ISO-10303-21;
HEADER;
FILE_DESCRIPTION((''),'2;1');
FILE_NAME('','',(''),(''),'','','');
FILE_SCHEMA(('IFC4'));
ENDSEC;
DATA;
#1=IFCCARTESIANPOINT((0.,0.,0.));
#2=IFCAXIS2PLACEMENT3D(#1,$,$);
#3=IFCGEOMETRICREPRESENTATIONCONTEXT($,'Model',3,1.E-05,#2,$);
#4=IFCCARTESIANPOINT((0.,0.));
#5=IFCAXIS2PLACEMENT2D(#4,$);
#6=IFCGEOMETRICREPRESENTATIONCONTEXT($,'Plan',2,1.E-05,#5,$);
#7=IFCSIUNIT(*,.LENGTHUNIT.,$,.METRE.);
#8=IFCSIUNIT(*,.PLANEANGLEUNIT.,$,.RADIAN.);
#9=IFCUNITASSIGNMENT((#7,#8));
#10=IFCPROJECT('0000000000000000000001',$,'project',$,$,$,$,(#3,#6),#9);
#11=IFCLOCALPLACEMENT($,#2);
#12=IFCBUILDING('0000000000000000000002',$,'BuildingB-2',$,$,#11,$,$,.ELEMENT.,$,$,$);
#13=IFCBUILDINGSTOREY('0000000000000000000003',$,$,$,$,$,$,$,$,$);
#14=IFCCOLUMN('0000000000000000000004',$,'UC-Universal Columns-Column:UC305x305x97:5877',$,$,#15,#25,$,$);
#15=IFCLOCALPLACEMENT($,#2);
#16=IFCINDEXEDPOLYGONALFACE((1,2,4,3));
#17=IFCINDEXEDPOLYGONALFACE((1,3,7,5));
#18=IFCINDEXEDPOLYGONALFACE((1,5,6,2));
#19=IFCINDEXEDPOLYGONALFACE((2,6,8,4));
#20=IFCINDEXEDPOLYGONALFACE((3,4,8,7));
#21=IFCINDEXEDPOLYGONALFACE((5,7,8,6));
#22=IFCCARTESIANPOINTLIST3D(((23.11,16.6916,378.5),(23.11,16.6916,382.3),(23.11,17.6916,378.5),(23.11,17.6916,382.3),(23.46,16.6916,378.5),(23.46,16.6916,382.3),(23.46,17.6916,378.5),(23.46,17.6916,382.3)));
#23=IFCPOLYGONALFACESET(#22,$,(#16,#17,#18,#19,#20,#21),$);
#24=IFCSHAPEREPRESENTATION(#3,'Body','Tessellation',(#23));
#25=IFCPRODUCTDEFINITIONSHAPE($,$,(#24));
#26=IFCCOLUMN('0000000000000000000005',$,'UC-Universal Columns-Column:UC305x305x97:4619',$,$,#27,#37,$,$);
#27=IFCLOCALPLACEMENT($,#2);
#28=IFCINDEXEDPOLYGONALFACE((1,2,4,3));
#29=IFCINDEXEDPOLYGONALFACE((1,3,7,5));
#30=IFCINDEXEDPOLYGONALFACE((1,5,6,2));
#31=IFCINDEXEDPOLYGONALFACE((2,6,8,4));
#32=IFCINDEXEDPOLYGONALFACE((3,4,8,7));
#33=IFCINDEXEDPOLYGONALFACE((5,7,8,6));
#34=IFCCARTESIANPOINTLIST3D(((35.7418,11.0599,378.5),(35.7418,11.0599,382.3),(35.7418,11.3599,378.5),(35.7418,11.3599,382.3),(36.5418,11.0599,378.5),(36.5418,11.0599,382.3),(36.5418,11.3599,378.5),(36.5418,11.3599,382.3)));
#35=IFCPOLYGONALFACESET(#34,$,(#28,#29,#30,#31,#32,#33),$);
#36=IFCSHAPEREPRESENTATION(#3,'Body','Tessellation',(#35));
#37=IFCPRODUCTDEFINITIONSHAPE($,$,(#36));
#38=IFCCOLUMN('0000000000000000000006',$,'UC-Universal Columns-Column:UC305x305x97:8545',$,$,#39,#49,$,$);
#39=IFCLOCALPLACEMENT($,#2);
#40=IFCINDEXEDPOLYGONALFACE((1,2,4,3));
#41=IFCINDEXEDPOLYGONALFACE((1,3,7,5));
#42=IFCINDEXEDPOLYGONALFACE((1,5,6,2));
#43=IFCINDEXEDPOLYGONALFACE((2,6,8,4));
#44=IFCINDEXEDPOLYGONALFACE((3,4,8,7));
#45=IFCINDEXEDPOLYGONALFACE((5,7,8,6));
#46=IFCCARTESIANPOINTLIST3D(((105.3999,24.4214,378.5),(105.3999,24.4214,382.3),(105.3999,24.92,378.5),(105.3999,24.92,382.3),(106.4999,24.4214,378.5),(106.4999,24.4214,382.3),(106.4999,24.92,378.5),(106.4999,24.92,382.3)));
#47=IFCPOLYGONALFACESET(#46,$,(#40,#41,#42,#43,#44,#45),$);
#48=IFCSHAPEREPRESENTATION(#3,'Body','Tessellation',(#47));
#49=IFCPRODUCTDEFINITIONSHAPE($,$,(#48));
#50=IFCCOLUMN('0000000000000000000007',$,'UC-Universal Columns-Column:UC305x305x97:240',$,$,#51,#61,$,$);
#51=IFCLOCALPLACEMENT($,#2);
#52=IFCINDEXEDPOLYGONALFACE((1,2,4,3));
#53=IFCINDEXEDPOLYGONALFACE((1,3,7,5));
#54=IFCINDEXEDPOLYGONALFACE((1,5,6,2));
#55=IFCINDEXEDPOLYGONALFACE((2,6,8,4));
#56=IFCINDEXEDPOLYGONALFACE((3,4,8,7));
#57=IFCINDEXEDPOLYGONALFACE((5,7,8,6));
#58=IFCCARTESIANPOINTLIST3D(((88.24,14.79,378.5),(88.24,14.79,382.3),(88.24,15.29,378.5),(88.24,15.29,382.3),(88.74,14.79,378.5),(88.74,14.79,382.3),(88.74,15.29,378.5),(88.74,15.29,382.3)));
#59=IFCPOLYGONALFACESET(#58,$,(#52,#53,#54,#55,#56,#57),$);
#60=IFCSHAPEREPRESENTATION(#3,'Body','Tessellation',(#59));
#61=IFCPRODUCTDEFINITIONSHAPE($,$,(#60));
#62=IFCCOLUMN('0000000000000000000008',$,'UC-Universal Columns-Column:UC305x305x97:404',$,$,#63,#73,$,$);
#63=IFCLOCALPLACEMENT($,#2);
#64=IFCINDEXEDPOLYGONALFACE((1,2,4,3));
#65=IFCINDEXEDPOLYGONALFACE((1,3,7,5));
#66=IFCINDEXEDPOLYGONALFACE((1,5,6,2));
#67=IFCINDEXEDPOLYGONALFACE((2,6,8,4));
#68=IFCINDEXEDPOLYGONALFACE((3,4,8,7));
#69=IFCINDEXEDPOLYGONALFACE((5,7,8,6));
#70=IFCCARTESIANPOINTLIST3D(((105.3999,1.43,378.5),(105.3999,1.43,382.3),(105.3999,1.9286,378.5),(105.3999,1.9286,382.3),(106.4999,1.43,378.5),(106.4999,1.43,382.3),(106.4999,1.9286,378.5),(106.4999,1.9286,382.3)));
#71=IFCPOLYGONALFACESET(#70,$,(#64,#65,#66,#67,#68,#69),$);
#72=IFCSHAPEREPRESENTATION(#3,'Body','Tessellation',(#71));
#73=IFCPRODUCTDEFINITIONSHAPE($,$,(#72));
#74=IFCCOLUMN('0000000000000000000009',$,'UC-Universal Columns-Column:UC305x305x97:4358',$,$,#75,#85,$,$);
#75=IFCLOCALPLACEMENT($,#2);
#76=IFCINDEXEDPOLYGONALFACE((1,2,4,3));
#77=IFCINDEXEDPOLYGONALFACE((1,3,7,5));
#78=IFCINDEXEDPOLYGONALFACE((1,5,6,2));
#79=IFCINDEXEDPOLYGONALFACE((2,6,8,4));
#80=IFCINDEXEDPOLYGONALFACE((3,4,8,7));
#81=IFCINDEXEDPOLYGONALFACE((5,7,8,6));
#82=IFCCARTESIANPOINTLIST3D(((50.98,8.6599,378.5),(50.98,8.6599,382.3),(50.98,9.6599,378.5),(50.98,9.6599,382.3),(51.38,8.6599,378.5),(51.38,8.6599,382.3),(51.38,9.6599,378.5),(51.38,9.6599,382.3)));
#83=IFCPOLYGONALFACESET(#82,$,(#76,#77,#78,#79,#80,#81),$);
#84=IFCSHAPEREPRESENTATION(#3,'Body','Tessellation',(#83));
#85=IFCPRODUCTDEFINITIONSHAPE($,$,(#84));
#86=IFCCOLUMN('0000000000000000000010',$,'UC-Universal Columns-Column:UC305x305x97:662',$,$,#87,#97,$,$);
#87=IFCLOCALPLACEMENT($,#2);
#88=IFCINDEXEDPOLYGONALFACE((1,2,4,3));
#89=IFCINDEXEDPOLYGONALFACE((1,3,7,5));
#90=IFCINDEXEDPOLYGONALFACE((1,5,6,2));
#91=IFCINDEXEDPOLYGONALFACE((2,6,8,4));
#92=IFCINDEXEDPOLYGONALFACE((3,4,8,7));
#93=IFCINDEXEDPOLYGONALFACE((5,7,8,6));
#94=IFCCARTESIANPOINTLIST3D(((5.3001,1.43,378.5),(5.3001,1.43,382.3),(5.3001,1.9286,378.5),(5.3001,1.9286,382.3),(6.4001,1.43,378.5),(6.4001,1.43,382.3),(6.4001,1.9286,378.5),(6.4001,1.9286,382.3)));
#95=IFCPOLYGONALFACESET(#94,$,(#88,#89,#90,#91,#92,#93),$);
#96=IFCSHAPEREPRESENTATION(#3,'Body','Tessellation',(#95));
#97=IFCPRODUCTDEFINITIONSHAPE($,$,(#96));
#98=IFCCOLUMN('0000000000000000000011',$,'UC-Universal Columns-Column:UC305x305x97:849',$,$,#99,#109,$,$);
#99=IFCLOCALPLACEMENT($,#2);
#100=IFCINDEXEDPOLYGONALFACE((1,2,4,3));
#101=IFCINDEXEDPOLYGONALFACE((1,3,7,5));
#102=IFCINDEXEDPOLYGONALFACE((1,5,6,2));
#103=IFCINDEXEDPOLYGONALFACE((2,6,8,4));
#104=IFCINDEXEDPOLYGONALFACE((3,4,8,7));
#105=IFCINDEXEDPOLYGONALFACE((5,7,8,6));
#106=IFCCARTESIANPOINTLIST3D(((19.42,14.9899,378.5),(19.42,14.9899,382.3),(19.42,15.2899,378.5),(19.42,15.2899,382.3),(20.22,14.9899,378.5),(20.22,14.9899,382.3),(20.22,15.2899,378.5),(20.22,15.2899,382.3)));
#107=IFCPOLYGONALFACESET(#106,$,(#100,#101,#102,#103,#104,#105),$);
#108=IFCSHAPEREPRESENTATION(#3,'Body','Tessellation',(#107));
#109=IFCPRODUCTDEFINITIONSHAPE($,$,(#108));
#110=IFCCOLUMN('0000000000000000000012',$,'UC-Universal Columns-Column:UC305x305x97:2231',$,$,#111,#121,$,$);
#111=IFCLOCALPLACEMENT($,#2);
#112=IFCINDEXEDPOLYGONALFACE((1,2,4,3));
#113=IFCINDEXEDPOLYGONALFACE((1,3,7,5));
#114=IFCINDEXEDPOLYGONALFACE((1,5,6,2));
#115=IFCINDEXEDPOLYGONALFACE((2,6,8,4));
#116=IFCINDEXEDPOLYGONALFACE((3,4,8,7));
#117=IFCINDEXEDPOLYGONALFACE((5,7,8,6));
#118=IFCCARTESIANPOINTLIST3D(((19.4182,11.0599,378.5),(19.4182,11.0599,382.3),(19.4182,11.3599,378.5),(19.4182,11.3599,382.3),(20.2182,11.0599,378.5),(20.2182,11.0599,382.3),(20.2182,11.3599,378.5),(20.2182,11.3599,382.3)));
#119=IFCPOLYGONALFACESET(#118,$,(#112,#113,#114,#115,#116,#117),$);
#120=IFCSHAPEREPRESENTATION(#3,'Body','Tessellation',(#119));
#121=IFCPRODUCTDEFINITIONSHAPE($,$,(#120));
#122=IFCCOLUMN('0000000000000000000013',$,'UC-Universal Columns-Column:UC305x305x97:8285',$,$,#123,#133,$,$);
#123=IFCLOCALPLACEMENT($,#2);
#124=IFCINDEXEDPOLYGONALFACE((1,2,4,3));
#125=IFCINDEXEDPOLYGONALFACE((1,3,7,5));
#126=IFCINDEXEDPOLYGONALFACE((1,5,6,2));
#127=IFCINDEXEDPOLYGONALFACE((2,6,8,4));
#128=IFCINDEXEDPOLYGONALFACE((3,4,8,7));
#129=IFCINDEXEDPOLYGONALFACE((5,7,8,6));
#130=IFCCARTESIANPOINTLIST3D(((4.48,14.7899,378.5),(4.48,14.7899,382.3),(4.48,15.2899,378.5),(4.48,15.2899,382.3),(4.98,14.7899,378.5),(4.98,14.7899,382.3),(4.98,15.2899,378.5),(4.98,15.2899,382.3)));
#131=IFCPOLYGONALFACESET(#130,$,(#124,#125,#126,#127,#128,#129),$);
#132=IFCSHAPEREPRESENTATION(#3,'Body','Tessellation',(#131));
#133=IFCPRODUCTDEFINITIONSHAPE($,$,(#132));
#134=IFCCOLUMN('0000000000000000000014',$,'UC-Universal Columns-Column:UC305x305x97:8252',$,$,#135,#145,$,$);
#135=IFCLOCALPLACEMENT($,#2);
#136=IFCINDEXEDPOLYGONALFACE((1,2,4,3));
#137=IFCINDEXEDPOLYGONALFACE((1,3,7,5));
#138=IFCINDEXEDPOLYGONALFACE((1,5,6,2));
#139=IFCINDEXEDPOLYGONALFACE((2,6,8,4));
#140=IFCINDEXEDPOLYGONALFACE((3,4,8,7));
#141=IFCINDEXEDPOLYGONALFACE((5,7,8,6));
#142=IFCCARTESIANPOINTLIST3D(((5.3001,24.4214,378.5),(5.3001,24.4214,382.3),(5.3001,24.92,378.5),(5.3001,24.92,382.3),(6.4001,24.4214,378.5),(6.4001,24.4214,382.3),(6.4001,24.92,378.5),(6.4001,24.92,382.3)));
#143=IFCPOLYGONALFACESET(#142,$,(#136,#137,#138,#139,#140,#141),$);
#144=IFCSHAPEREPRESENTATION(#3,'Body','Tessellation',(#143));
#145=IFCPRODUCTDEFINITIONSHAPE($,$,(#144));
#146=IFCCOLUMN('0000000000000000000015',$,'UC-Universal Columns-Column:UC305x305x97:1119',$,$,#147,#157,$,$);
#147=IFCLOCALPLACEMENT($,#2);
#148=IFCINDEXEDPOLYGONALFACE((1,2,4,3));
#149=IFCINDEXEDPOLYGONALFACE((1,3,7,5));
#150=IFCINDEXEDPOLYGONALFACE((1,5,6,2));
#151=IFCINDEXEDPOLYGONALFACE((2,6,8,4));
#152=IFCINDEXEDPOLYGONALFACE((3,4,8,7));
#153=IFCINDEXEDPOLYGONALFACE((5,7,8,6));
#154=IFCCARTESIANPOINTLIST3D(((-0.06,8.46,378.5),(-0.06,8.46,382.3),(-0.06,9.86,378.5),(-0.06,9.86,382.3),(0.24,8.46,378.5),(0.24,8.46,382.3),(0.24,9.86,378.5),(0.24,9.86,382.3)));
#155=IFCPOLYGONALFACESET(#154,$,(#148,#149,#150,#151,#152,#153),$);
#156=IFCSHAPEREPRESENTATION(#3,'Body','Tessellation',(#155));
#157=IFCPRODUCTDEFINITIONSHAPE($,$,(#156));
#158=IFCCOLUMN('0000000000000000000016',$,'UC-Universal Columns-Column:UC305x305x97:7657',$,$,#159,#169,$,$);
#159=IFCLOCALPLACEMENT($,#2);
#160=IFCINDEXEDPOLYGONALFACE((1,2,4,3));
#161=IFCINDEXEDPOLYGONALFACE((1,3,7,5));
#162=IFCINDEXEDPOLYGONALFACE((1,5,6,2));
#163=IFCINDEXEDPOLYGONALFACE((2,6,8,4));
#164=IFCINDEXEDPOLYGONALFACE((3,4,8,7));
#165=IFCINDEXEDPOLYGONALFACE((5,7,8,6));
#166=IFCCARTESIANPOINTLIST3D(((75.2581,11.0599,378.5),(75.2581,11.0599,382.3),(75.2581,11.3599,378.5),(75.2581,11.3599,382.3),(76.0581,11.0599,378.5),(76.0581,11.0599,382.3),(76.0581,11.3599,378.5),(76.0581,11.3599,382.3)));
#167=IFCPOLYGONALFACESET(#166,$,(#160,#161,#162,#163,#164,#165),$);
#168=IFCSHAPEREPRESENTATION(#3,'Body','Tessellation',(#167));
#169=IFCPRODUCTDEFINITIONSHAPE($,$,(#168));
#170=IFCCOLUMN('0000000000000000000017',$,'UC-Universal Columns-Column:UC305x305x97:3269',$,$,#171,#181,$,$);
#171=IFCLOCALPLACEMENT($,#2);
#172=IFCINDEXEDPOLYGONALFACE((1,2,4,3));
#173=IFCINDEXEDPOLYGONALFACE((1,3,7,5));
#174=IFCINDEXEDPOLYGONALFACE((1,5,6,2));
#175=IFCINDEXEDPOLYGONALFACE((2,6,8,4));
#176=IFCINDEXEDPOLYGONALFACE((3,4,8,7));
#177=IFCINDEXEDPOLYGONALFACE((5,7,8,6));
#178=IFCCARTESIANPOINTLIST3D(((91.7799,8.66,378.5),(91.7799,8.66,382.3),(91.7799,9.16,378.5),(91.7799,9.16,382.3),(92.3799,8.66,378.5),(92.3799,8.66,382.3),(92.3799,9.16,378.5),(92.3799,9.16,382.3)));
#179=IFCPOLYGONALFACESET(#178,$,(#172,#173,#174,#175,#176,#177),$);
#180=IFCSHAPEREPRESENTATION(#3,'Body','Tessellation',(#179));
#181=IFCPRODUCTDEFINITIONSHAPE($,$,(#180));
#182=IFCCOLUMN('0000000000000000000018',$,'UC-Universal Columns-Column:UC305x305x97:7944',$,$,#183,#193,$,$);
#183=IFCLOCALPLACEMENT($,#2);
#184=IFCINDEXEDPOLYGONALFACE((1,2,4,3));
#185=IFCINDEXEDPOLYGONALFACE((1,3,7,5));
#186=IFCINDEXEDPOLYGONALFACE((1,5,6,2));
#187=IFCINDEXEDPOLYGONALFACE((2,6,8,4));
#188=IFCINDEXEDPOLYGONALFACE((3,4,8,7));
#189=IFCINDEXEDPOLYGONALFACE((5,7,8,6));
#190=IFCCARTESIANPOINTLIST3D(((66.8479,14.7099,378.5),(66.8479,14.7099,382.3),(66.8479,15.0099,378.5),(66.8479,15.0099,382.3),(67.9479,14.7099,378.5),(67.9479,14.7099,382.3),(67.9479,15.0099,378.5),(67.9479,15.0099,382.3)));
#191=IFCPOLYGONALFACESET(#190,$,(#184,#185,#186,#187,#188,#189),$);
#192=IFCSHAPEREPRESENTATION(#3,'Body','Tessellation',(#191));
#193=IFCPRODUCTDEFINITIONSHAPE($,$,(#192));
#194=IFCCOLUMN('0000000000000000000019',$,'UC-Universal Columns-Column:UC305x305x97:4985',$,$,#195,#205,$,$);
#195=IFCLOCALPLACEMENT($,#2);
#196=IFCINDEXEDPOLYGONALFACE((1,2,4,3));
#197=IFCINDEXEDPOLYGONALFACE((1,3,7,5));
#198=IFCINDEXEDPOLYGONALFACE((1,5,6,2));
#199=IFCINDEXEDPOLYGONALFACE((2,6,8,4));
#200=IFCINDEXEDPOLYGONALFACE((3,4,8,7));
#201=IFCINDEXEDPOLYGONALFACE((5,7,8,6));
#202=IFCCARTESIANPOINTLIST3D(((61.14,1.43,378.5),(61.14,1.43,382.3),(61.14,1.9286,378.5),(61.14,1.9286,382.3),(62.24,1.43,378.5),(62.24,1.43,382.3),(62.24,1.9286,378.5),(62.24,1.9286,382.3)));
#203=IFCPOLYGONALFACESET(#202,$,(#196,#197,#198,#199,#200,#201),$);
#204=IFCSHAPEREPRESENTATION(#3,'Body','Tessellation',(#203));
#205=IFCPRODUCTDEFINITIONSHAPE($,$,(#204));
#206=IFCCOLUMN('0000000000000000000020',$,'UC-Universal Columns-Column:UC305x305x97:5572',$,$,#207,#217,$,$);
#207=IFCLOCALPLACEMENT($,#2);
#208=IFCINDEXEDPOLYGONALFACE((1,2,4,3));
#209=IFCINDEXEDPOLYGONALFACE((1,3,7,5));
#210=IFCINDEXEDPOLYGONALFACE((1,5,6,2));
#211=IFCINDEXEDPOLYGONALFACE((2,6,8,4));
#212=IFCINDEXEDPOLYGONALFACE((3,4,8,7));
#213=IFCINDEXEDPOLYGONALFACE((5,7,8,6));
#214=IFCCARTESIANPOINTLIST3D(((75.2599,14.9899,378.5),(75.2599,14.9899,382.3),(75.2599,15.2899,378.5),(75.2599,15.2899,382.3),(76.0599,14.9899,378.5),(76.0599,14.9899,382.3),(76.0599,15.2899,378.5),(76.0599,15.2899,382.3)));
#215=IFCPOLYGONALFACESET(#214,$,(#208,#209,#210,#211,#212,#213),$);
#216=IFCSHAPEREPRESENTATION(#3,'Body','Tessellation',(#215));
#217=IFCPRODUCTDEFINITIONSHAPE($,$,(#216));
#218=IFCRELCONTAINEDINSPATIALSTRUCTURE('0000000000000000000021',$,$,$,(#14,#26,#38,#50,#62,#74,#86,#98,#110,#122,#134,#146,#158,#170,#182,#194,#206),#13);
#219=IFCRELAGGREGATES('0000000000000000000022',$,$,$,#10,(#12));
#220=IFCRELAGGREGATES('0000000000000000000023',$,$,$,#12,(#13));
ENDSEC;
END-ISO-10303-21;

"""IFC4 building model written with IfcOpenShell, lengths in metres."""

from ifc_helpers import new_model, si_unit, origin, origin_2d, place, context, project, spatial, polyline, outline, extrude, element, save


model = new_model("IFC4")

# Units and contexts
model_context = context("Model", 3, precision=1e-05, world=origin())
plan_context = context("Plan", 2, precision=1e-05, world=origin_2d())
ifc_project = project(units=[si_unit("LENGTHUNIT", "METRE"), si_unit("PLANEANGLEUNIT", "RADIAN")], contexts=[model_context, plan_context])

# Building, storey
building_placement = place(None, origin())
building = spatial("IfcBuilding", under=ifc_project, at=building_placement, Name="BuildingB-2", CompositionType="ELEMENT")
storey = spatial("IfcBuildingStorey", under=building)

# Columns
element("IfcColumn", 1, inside=storey, Name="UC-Universal Columns-Column:UC305x305x97:5877", context=model_context, shape_type="SweptSolid", body=[
    extrude(outline(polyline([(23.46, 17.6916, 382.3), (23.11, 17.6916, 382.3), (23.11, 16.6916, 382.3), (23.46, 16.6916, 382.3), (23.46, 17.6916, 382.3)])), None, (0.0, 0.0, -1.0), 3.8),
])
element("IfcColumn", 2, inside=storey, Name="UC-Universal Columns-Column:UC305x305x97:4619", context=model_context, shape_type="SweptSolid", body=[
    extrude(outline(polyline([(36.5418, 11.0599, 382.3), (35.7418, 11.0599, 382.3), (35.7418, 11.3599, 382.3), (36.5418, 11.3599, 382.3), (36.5418, 11.0599, 382.3)])), None, (0.0, 0.0, -1.0), 3.8),
])
element("IfcColumn", 3, inside=storey, Name="UC-Universal Columns-Column:UC305x305x97:8545", context=model_context, shape_type="SweptSolid", body=[
    extrude(outline(polyline([(106.4999, 24.4214, 382.3), (105.3999, 24.4214, 382.3), (105.3999, 24.92, 382.3), (106.4999, 24.92, 382.3), (106.4999, 24.4214, 382.3)])), None, (0.0, 0.0, -1.0), 3.8),
])
element("IfcColumn", 4, inside=storey, Name="UC-Universal Columns-Column:UC305x305x97:240", context=model_context, shape_type="SweptSolid", body=[
    extrude(outline(polyline([(88.74, 15.29, 382.3), (88.24, 15.29, 382.3), (88.24, 14.79, 382.3), (88.74, 14.79, 382.3), (88.74, 15.29, 382.3)])), None, (0.0, 0.0, -1.0), 3.8),
])
element("IfcColumn", 5, inside=storey, Name="UC-Universal Columns-Column:UC305x305x97:404", context=model_context, shape_type="SweptSolid", body=[
    extrude(outline(polyline([(106.4999, 1.43, 382.3), (105.3999, 1.43, 382.3), (105.3999, 1.9286, 382.3), (106.4999, 1.9286, 382.3), (106.4999, 1.43, 382.3)])), None, (0.0, 0.0, -1.0), 3.8),
])
element("IfcColumn", 6, inside=storey, Name="UC-Universal Columns-Column:UC305x305x97:4358", context=model_context, shape_type="SweptSolid", body=[
    extrude(outline(polyline([(51.38, 8.6599, 382.3), (50.98, 8.6599, 382.3), (50.98, 9.6599, 382.3), (51.38, 9.6599, 382.3), (51.38, 8.6599, 382.3)])), None, (0.0, 0.0, -1.0), 3.8),
])
element("IfcColumn", 7, inside=storey, Name="UC-Universal Columns-Column:UC305x305x97:662", context=model_context, shape_type="SweptSolid", body=[
    extrude(outline(polyline([(5.3001, 1.43, 382.3), (6.4001, 1.43, 382.3), (6.4001, 1.9286, 382.3), (5.3001, 1.9286, 382.3), (5.3001, 1.43, 382.3)])), None, (0.0, 0.0, -1.0), 3.8),
])
element("IfcColumn", 8, inside=storey, Name="UC-Universal Columns-Column:UC305x305x97:849", context=model_context, shape_type="SweptSolid", body=[
    extrude(outline(polyline([(19.42, 15.2899, 382.3), (20.22, 15.2899, 382.3), (20.22, 14.9899, 382.3), (19.42, 14.9899, 382.3), (19.42, 15.2899, 382.3)])), None, (0.0, 0.0, -1.0), 3.8),
])
element("IfcColumn", 9, inside=storey, Name="UC-Universal Columns-Column:UC305x305x97:2231", context=model_context, shape_type="SweptSolid", body=[
    extrude(outline(polyline([(19.4182, 11.0599, 382.3), (20.2182, 11.0599, 382.3), (20.2182, 11.3599, 382.3), (19.4182, 11.3599, 382.3), (19.4182, 11.0599, 382.3)])), None, (0.0, 0.0, -1.0), 3.8),
])
element("IfcColumn", 10, inside=storey, Name="UC-Universal Columns-Column:UC305x305x97:8285", context=model_context, shape_type="SweptSolid", body=[
    extrude(outline(polyline([(4.98, 15.2899, 382.3), (4.48, 15.2899, 382.3), (4.48, 14.7899, 382.3), (4.98, 14.7899, 382.3), (4.98, 15.2899, 382.3)])), None, (0.0, 0.0, -1.0), 3.8),
])
element("IfcColumn", 11, inside=storey, Name="UC-Universal Columns-Column:UC305x305x97:8252", context=model_context, shape_type="SweptSolid", body=[
    extrude(outline(polyline([(5.3001, 24.4214, 382.3), (6.4001, 24.4214, 382.3), (6.4001, 24.92, 382.3), (5.3001, 24.92, 382.3), (5.3001, 24.4214, 382.3)])), None, (0.0, 0.0, -1.0), 3.8),
])
element("IfcColumn", 12, inside=storey, Name="UC-Universal Columns-Column:UC305x305x97:1119", context=model_context, shape_type="SweptSolid", body=[
    extrude(outline(polyline([(-0.06, 8.46, 382.3), (0.24, 8.46, 382.3), (0.24, 9.86, 382.3), (-0.06, 9.86, 382.3), (-0.06, 8.46, 382.3)])), None, (0.0, 0.0, -1.0), 3.8),
])
element("IfcColumn", 13, inside=storey, Name="UC-Universal Columns-Column:UC305x305x97:7657", context=model_context, shape_type="SweptSolid", body=[
    extrude(outline(polyline([(75.2581, 11.0599, 382.3), (76.0581, 11.0599, 382.3), (76.0581, 11.3599, 382.3), (75.2581, 11.3599, 382.3), (75.2581, 11.0599, 382.3)])), None, (0.0, 0.0, -1.0), 3.8),
])
element("IfcColumn", 14, inside=storey, Name="UC-Universal Columns-Column:UC305x305x97:3269", context=model_context, shape_type="SweptSolid", body=[
    extrude(outline(polyline([(92.3799, 8.66, 382.3), (91.7799, 8.66, 382.3), (91.7799, 9.16, 382.3), (92.3799, 9.16, 382.3), (92.3799, 8.66, 382.3)])), None, (0.0, 0.0, -1.0), 3.8),
])
element("IfcColumn", 15, inside=storey, Name="UC-Universal Columns-Column:UC305x305x97:7944", context=model_context, shape_type="SweptSolid", body=[
    extrude(outline(polyline([(66.8479, 14.7099, 382.3), (66.8479, 15.0099, 382.3), (67.9479, 15.0099, 382.3), (67.9479, 14.7099, 382.3), (66.8479, 14.7099, 382.3)])), None, (0.0, 0.0, -1.0), 3.8),
])
element("IfcColumn", 16, inside=storey, Name="UC-Universal Columns-Column:UC305x305x97:4985", context=model_context, shape_type="SweptSolid", body=[
    extrude(outline(polyline([(61.14, 1.43, 382.3), (62.24, 1.43, 382.3), (62.24, 1.9286, 382.3), (61.14, 1.9286, 382.3), (61.14, 1.43, 382.3)])), None, (0.0, 0.0, -1.0), 3.8),
])
element("IfcColumn", 17, inside=storey, Name="UC-Universal Columns-Column:UC305x305x97:5572", context=model_context, shape_type="SweptSolid", body=[
    extrude(outline(polyline([(75.2599, 15.2899, 382.3), (76.0599, 15.2899, 382.3), (76.0599, 14.9899, 382.3), (75.2599, 14.9899, 382.3), (75.2599, 15.2899, 382.3)])), None, (0.0, 0.0, -1.0), 3.8),
])

save(model, "model.ifc")
